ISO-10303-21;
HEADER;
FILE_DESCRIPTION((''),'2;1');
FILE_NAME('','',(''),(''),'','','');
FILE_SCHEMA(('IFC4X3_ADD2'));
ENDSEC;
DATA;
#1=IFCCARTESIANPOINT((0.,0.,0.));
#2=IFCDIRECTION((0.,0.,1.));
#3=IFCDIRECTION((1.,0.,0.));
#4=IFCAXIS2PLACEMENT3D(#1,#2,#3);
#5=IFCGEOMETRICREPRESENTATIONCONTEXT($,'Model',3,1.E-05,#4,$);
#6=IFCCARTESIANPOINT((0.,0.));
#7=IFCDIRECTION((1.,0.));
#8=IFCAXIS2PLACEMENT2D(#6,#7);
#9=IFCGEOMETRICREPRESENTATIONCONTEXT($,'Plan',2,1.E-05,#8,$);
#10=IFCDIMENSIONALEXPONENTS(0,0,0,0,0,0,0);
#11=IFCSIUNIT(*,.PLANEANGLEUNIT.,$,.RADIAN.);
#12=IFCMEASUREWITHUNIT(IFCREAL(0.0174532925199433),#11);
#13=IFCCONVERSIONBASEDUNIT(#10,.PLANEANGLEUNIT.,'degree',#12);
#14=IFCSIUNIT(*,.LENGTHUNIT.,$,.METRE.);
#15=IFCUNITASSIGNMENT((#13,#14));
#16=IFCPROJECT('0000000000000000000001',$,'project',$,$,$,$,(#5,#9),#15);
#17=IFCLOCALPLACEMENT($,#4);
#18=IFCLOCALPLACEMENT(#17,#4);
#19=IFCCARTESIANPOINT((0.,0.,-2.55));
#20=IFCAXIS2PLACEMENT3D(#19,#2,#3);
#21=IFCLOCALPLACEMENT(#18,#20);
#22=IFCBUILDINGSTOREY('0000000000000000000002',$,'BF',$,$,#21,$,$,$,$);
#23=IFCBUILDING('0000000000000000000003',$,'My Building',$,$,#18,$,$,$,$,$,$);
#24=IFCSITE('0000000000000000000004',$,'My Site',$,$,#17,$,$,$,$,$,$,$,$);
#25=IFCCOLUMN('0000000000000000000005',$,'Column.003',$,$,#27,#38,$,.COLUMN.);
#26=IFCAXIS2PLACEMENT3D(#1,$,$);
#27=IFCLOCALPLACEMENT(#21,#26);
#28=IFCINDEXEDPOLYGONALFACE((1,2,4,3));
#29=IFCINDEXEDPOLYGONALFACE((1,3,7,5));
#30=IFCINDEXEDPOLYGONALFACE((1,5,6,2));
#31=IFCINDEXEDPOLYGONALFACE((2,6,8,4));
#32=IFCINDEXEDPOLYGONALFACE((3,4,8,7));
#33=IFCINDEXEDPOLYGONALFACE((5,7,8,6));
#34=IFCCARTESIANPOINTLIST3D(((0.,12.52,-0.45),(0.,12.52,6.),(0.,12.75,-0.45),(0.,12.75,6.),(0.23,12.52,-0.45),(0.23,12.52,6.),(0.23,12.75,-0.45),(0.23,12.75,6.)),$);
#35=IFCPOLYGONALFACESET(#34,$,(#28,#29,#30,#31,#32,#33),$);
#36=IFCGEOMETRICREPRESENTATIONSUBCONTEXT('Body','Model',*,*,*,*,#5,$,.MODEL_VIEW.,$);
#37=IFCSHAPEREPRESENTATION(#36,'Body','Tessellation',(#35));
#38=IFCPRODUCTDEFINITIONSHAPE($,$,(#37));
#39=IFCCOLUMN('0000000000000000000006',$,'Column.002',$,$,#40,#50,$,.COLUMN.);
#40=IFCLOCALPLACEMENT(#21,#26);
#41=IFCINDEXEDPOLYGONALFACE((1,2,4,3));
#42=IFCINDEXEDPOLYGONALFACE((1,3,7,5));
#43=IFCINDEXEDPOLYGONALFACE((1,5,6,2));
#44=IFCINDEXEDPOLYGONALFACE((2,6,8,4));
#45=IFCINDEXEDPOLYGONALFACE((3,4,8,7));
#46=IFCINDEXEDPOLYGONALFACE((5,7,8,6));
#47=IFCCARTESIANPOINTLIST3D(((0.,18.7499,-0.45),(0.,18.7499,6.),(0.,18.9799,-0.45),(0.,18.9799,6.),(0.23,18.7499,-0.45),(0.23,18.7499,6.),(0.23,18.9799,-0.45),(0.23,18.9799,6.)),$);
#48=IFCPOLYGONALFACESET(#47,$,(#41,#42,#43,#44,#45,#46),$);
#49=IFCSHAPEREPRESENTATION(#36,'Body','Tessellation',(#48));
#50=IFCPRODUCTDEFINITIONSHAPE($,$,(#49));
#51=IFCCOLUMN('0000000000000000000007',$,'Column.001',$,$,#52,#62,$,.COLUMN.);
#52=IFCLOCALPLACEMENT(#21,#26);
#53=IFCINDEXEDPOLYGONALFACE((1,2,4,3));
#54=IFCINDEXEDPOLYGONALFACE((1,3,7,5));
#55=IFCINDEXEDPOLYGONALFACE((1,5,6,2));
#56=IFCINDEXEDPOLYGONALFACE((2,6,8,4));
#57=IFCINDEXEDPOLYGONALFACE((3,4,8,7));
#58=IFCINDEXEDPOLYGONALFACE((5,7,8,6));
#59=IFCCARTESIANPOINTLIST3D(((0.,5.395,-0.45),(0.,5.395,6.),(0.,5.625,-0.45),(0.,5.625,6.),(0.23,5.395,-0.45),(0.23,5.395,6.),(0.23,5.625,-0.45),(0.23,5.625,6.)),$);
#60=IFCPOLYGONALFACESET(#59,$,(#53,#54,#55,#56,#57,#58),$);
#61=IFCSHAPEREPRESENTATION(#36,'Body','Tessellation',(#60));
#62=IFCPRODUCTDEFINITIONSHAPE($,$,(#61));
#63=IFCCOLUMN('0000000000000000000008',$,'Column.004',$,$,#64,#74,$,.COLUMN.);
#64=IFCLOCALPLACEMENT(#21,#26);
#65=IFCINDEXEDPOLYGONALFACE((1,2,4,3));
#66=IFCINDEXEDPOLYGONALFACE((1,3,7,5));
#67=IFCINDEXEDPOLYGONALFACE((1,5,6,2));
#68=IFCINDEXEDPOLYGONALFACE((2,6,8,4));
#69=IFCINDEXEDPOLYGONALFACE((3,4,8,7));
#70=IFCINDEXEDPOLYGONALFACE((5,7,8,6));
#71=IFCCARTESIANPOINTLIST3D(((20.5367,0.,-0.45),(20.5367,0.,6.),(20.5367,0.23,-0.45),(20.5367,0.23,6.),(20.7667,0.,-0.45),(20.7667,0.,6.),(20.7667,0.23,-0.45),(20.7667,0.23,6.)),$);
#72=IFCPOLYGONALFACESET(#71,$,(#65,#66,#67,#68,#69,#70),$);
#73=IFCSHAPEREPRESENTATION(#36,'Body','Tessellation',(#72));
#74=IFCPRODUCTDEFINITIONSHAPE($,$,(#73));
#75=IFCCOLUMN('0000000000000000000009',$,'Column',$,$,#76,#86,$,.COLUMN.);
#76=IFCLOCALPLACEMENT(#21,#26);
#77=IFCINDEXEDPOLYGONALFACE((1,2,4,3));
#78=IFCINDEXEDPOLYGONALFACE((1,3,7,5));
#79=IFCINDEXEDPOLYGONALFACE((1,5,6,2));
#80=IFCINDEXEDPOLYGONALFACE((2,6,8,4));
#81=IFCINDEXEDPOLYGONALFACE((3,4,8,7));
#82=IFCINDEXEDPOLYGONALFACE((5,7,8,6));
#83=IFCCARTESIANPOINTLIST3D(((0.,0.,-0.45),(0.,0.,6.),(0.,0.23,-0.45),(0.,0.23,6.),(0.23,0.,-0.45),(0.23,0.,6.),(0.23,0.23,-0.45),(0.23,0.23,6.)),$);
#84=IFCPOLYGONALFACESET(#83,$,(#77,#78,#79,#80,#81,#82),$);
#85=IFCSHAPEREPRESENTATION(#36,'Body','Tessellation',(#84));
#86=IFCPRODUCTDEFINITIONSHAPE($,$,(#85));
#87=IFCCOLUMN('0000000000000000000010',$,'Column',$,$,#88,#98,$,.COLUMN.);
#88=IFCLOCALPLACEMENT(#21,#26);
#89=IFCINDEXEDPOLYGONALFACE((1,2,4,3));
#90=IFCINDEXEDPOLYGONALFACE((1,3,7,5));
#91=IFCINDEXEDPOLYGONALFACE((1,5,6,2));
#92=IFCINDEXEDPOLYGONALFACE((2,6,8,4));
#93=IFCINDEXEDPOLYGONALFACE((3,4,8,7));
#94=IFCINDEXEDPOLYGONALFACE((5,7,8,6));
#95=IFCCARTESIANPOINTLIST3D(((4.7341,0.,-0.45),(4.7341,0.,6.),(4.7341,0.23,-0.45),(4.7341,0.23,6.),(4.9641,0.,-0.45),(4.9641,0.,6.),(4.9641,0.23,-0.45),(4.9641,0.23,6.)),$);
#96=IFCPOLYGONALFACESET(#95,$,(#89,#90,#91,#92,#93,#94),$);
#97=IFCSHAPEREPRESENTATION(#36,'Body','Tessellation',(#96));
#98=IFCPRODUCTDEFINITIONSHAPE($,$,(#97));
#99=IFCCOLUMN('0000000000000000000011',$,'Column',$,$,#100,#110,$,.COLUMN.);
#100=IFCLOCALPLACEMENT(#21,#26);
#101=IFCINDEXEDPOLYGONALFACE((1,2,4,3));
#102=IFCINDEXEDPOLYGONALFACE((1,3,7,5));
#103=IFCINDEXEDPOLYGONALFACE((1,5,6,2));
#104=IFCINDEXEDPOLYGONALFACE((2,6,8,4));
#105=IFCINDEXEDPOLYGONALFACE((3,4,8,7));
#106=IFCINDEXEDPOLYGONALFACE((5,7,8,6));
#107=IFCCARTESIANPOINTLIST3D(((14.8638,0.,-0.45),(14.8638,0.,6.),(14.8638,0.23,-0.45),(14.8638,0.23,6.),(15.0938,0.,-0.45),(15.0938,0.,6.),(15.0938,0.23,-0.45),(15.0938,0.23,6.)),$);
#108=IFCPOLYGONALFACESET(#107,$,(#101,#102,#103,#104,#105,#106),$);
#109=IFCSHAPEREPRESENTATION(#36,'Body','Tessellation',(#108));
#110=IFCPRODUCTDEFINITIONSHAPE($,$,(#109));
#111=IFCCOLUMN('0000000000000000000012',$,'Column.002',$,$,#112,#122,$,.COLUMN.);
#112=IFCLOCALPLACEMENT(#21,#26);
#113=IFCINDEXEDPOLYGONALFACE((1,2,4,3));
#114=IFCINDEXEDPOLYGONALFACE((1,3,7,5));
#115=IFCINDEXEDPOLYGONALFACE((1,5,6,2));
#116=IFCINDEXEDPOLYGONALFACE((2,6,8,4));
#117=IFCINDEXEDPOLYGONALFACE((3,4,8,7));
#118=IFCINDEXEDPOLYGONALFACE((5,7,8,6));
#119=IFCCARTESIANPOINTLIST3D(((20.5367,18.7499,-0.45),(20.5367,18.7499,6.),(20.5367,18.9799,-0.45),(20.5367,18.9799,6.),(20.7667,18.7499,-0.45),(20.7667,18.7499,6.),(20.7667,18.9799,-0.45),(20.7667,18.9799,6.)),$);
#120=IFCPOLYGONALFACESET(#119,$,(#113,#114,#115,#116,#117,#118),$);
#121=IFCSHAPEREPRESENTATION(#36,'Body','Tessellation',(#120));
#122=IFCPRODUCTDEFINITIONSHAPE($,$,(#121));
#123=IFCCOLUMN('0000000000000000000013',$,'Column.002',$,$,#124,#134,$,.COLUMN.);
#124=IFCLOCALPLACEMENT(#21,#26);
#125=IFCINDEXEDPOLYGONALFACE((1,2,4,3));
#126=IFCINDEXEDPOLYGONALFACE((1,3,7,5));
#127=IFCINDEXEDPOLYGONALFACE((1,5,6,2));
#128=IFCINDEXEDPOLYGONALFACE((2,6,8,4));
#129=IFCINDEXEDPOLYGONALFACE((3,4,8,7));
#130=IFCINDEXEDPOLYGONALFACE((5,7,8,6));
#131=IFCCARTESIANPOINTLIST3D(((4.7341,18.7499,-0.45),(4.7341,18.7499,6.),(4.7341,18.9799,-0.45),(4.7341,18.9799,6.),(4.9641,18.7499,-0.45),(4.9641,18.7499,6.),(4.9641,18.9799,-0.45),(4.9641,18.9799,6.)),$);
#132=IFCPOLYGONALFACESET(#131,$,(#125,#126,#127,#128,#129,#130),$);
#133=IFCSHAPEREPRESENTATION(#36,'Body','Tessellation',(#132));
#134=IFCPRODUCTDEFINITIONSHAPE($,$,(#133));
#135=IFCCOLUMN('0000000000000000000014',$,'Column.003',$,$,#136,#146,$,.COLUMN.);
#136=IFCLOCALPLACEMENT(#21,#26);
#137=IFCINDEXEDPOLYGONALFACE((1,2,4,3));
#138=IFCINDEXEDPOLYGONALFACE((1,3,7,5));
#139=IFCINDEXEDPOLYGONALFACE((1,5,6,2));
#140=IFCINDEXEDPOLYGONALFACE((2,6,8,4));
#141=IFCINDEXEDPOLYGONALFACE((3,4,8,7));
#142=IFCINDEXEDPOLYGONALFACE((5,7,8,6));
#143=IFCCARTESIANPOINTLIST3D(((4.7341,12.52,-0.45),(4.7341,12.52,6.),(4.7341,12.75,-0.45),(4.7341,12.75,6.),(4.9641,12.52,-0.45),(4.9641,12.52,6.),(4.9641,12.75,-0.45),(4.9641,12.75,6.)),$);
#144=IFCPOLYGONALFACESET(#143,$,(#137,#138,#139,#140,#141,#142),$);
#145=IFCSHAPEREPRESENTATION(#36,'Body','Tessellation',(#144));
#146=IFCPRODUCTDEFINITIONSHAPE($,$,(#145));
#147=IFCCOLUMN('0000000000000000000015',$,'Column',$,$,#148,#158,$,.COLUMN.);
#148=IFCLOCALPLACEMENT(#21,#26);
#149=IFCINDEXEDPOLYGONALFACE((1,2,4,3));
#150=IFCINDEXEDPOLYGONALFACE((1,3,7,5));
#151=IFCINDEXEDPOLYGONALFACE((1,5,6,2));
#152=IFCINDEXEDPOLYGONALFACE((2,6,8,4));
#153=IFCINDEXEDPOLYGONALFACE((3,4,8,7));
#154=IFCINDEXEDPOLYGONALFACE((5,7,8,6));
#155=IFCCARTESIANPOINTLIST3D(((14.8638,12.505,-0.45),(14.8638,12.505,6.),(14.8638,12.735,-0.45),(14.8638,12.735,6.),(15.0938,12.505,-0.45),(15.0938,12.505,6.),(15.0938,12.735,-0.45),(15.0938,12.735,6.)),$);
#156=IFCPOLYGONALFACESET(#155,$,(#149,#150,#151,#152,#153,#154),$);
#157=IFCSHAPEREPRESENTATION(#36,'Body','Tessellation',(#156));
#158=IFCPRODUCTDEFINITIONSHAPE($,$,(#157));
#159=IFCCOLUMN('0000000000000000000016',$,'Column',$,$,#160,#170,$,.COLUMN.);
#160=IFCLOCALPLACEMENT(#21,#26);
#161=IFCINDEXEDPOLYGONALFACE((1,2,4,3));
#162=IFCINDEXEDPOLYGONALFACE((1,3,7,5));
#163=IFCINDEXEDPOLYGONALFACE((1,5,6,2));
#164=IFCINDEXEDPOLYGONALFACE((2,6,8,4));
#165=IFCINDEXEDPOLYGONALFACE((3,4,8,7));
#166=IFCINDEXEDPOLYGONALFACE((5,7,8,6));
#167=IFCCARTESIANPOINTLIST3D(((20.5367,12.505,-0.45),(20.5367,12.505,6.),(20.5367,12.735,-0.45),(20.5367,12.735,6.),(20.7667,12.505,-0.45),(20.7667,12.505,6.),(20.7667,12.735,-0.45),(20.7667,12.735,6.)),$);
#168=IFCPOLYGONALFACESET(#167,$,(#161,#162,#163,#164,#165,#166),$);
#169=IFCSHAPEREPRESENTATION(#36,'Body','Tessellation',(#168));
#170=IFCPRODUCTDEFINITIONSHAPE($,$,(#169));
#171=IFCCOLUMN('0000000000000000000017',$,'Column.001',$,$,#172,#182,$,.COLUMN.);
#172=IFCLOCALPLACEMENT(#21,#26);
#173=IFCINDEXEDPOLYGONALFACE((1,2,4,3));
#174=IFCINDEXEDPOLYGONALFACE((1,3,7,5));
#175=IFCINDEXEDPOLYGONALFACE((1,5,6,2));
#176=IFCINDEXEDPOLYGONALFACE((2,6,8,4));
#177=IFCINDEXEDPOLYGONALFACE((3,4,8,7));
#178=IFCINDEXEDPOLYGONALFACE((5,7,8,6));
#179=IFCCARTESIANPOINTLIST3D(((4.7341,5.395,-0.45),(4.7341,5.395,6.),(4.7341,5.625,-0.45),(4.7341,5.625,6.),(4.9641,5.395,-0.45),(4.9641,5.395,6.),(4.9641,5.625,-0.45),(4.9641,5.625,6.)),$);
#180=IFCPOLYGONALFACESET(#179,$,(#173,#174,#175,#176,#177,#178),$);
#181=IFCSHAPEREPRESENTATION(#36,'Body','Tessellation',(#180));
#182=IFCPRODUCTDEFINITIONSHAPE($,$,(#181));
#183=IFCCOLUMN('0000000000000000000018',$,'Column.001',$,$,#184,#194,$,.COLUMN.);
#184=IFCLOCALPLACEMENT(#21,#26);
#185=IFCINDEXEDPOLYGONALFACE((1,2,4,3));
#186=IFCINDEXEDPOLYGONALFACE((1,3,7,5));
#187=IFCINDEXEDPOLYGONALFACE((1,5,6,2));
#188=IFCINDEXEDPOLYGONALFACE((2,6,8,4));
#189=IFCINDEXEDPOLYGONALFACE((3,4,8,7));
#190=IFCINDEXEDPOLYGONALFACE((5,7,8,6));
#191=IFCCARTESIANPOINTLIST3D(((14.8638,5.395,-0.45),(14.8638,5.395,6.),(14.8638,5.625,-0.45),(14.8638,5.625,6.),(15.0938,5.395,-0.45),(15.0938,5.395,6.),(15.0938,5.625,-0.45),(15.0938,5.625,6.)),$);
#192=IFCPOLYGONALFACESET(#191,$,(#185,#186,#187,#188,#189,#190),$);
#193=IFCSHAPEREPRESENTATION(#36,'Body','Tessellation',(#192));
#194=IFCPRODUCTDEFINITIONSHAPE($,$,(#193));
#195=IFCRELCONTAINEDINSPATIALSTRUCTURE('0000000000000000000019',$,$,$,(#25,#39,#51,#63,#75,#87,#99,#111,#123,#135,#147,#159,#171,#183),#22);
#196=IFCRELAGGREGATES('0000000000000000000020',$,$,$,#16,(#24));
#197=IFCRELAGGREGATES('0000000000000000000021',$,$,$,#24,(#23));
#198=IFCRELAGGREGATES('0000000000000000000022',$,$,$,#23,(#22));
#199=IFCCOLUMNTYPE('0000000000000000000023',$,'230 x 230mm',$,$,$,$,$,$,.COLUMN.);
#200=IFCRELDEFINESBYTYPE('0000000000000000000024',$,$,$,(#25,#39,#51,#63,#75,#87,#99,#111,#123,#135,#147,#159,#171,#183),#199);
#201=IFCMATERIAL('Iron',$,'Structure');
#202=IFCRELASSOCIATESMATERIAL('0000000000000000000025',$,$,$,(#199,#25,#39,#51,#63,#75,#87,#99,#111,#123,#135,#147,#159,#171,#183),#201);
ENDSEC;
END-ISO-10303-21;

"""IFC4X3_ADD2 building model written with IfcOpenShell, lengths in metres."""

from ifc_helpers import new_model, entity, si_unit, converted_unit, frame, origin_with_axes, origin_2d_with_axis, place, context, subcontext, project, spatial, rectangle, extrude, material, material_profile, profile_set, profile_usage, type_object, element, save


model = new_model("IFC4X3_ADD2")

# Units and contexts
model_context = context("Model", 3, precision=1e-05, world=origin_with_axes())
plan_context = context("Plan", 2, precision=1e-05, world=origin_2d_with_axis())
body_context_1 = subcontext(model_context, "Body", "Model", "MODEL_VIEW")
ifc_project = project(units=[converted_unit("PLANEANGLEUNIT", "degree", entity("IfcReal", 0.0174532925199433), si_unit("PLANEANGLEUNIT", "RADIAN"), dimensions=[0, 0, 0, 0, 0, 0, 0]), si_unit("LENGTHUNIT", "METRE")], contexts=[model_context, plan_context])

# Site, building, storey
site_placement = place(None, origin_with_axes())
site = spatial("IfcSite", under=ifc_project, at=site_placement, Name="My Site")
building_placement = place(site_placement, origin_with_axes())
building = spatial("IfcBuilding", under=site, at=building_placement, Name="My Building")
storey_placement = place(building_placement, frame((0.0, 0.0, -2.55), z_axis=(0.0, 0.0, 1.0), x_axis=(1.0, 0.0, 0.0)))
storey = spatial("IfcBuildingStorey", under=building, at=storey_placement, Name="BF")

# Columns
ifc_material_1 = material(Name="Iron", Category="Structure")
ifc_material_profile = material_profile(ifc_material_1, rectangle(XDim=0.23, YDim=0.23))
ifc_profile_set = profile_set([ifc_material_profile])
ifc_profile_usage_1 = profile_usage(ifc_profile_set)
column_type = type_object("IfcColumnType", Name="230 x 230mm", PredefinedType="COLUMN", material=ifc_profile_set)
column_1_placement = place(storey_placement, frame((0.115, 12.635, -0.45), z_axis=(0.0, 0.0, 1.0), x_axis=(1.0, 0.0, 0.0)))
element("IfcColumn", 1, at=column_1_placement, inside=storey, type_object=column_type, material=ifc_profile_usage_1, Name="Column.003", PredefinedType="COLUMN", context=body_context_1, shape_type="SweptSolid", body=[
    extrude(rectangle(XDim=0.23, YDim=0.23), origin_with_axes(), (0.0, 0.0, 1.0), 6.45),
])
ifc_profile_usage_2 = profile_usage(ifc_profile_set)
column_2_placement = place(storey_placement, frame((0.115, 18.8649, -0.45), z_axis=(0.0, 0.0, 1.0), x_axis=(1.0, 0.0, 0.0)))
element("IfcColumn", 2, at=column_2_placement, inside=storey, type_object=column_type, material=ifc_profile_usage_2, Name="Column.002", PredefinedType="COLUMN", context=body_context_1, shape_type="SweptSolid", body=[
    extrude(rectangle(XDim=0.23, YDim=0.23), origin_with_axes(), (0.0, 0.0, 1.0), 6.45),
])
ifc_profile_usage_3 = profile_usage(ifc_profile_set)
column_3_placement = place(storey_placement, frame((0.115, 5.51, -0.45), z_axis=(0.0, 0.0, 1.0), x_axis=(1.0, 0.0, 0.0)))
element("IfcColumn", 3, at=column_3_placement, inside=storey, type_object=column_type, material=ifc_profile_usage_3, Name="Column.001", PredefinedType="COLUMN", context=body_context_1, shape_type="SweptSolid", body=[
    extrude(rectangle(XDim=0.23, YDim=0.23), origin_with_axes(), (0.0, 0.0, 1.0), 6.45),
])
ifc_profile_usage_4 = profile_usage(ifc_profile_set)
column_4_placement = place(storey_placement, frame((20.6517, 0.115, -0.45), z_axis=(0.0, 0.0, 1.0), x_axis=(1.0, 0.0, 0.0)))
element("IfcColumn", 4, at=column_4_placement, inside=storey, type_object=column_type, material=ifc_profile_usage_4, Name="Column.004", PredefinedType="COLUMN", context=body_context_1, shape_type="SweptSolid", body=[
    extrude(rectangle(XDim=0.23, YDim=0.23), origin_with_axes(), (0.0, 0.0, 1.0), 6.45),
])
ifc_profile_usage_5 = profile_usage(ifc_profile_set)
column_5_placement = place(storey_placement, frame((0.115, 0.115, -0.45), z_axis=(0.0, 0.0, 1.0), x_axis=(1.0, 0.0, 0.0)))
element("IfcColumn", 5, at=column_5_placement, inside=storey, type_object=column_type, material=ifc_profile_usage_5, Name="Column", PredefinedType="COLUMN", context=body_context_1, shape_type="SweptSolid", body=[
    extrude(rectangle(XDim=0.23, YDim=0.23), origin_with_axes(), (0.0, 0.0, 1.0), 6.45),
])
ifc_profile_usage_6 = profile_usage(ifc_profile_set)
column_6_placement = place(storey_placement, frame((4.8491, 0.115, -0.45), z_axis=(0.0, 0.0, 1.0), x_axis=(1.0, 0.0, 0.0)))
element("IfcColumn", 6, at=column_6_placement, inside=storey, type_object=column_type, material=ifc_profile_usage_6, Name="Column", PredefinedType="COLUMN", context=body_context_1, shape_type="SweptSolid", body=[
    extrude(rectangle(XDim=0.23, YDim=0.23), origin_with_axes(), (0.0, 0.0, 1.0), 6.45),
])
ifc_profile_usage_7 = profile_usage(ifc_profile_set)
column_7_placement = place(storey_placement, frame((14.9788, 0.115, -0.45), z_axis=(0.0, 0.0, 1.0), x_axis=(1.0, 0.0, 0.0)))
element("IfcColumn", 7, at=column_7_placement, inside=storey, type_object=column_type, material=ifc_profile_usage_7, Name="Column", PredefinedType="COLUMN", context=body_context_1, shape_type="SweptSolid", body=[
    extrude(rectangle(XDim=0.23, YDim=0.23), origin_with_axes(), (0.0, 0.0, 1.0), 6.45),
])
ifc_profile_usage_8 = profile_usage(ifc_profile_set)
column_8_placement = place(storey_placement, frame((20.6517, 18.8649, -0.45), z_axis=(0.0, 0.0, 1.0), x_axis=(1.0, 0.0, 0.0)))
element("IfcColumn", 8, at=column_8_placement, inside=storey, type_object=column_type, material=ifc_profile_usage_8, Name="Column.002", PredefinedType="COLUMN", context=body_context_1, shape_type="SweptSolid", body=[
    extrude(rectangle(XDim=0.23, YDim=0.23), origin_with_axes(), (0.0, 0.0, 1.0), 6.45),
])
ifc_profile_usage_9 = profile_usage(ifc_profile_set)
column_9_placement = place(storey_placement, frame((4.8491, 18.8649, -0.45), z_axis=(0.0, 0.0, 1.0), x_axis=(1.0, 0.0, 0.0)))
element("IfcColumn", 9, at=column_9_placement, inside=storey, type_object=column_type, material=ifc_profile_usage_9, Name="Column.002", PredefinedType="COLUMN", context=body_context_1, shape_type="SweptSolid", body=[
    extrude(rectangle(XDim=0.23, YDim=0.23), origin_with_axes(), (0.0, 0.0, 1.0), 6.45),
])
ifc_profile_usage_10 = profile_usage(ifc_profile_set)
column_10_placement = place(storey_placement, frame((4.8491, 12.635, -0.45), z_axis=(0.0, 0.0, 1.0), x_axis=(1.0, 0.0, 0.0)))
element("IfcColumn", 10, at=column_10_placement, inside=storey, type_object=column_type, material=ifc_profile_usage_10, Name="Column.003", PredefinedType="COLUMN", context=body_context_1, shape_type="SweptSolid", body=[
    extrude(rectangle(XDim=0.23, YDim=0.23), origin_with_axes(), (0.0, 0.0, 1.0), 6.45),
])
ifc_profile_usage_11 = profile_usage(ifc_profile_set)
column_11_placement = place(storey_placement, frame((14.9788, 12.62, -0.45), z_axis=(0.0, 0.0, 1.0), x_axis=(1.0, 0.0, 0.0)))
element("IfcColumn", 11, at=column_11_placement, inside=storey, type_object=column_type, material=ifc_profile_usage_11, Name="Column", PredefinedType="COLUMN", context=body_context_1, shape_type="SweptSolid", body=[
    extrude(rectangle(XDim=0.23, YDim=0.23), origin_with_axes(), (0.0, 0.0, 1.0), 6.45),
])
ifc_profile_usage_12 = profile_usage(ifc_profile_set)
column_12_placement = place(storey_placement, frame((20.6517, 12.62, -0.45), z_axis=(0.0, 0.0, 1.0), x_axis=(1.0, 0.0, 0.0)))
element("IfcColumn", 12, at=column_12_placement, inside=storey, type_object=column_type, material=ifc_profile_usage_12, Name="Column", PredefinedType="COLUMN", context=body_context_1, shape_type="SweptSolid", body=[
    extrude(rectangle(XDim=0.23, YDim=0.23), origin_with_axes(), (0.0, 0.0, 1.0), 6.45),
])
ifc_profile_usage_13 = profile_usage(ifc_profile_set)
column_13_placement = place(storey_placement, frame((4.8491, 5.51, -0.45), z_axis=(0.0, 0.0, 1.0), x_axis=(1.0, 0.0, 0.0)))
element("IfcColumn", 13, at=column_13_placement, inside=storey, type_object=column_type, material=ifc_profile_usage_13, Name="Column.001", PredefinedType="COLUMN", context=body_context_1, shape_type="SweptSolid", body=[
    extrude(rectangle(XDim=0.23, YDim=0.23), origin_with_axes(), (0.0, 0.0, 1.0), 6.45),
])
ifc_profile_usage_14 = profile_usage(ifc_profile_set)
column_14_placement = place(storey_placement, frame((14.9788, 5.51, -0.45), z_axis=(0.0, 0.0, 1.0), x_axis=(1.0, 0.0, 0.0)))
element("IfcColumn", 14, at=column_14_placement, inside=storey, type_object=column_type, material=ifc_profile_usage_14, Name="Column.001", PredefinedType="COLUMN", context=body_context_1, shape_type="SweptSolid", body=[
    extrude(rectangle(XDim=0.23, YDim=0.23), origin_with_axes(), (0.0, 0.0, 1.0), 6.45),
])

save(model, "model.ifc")
